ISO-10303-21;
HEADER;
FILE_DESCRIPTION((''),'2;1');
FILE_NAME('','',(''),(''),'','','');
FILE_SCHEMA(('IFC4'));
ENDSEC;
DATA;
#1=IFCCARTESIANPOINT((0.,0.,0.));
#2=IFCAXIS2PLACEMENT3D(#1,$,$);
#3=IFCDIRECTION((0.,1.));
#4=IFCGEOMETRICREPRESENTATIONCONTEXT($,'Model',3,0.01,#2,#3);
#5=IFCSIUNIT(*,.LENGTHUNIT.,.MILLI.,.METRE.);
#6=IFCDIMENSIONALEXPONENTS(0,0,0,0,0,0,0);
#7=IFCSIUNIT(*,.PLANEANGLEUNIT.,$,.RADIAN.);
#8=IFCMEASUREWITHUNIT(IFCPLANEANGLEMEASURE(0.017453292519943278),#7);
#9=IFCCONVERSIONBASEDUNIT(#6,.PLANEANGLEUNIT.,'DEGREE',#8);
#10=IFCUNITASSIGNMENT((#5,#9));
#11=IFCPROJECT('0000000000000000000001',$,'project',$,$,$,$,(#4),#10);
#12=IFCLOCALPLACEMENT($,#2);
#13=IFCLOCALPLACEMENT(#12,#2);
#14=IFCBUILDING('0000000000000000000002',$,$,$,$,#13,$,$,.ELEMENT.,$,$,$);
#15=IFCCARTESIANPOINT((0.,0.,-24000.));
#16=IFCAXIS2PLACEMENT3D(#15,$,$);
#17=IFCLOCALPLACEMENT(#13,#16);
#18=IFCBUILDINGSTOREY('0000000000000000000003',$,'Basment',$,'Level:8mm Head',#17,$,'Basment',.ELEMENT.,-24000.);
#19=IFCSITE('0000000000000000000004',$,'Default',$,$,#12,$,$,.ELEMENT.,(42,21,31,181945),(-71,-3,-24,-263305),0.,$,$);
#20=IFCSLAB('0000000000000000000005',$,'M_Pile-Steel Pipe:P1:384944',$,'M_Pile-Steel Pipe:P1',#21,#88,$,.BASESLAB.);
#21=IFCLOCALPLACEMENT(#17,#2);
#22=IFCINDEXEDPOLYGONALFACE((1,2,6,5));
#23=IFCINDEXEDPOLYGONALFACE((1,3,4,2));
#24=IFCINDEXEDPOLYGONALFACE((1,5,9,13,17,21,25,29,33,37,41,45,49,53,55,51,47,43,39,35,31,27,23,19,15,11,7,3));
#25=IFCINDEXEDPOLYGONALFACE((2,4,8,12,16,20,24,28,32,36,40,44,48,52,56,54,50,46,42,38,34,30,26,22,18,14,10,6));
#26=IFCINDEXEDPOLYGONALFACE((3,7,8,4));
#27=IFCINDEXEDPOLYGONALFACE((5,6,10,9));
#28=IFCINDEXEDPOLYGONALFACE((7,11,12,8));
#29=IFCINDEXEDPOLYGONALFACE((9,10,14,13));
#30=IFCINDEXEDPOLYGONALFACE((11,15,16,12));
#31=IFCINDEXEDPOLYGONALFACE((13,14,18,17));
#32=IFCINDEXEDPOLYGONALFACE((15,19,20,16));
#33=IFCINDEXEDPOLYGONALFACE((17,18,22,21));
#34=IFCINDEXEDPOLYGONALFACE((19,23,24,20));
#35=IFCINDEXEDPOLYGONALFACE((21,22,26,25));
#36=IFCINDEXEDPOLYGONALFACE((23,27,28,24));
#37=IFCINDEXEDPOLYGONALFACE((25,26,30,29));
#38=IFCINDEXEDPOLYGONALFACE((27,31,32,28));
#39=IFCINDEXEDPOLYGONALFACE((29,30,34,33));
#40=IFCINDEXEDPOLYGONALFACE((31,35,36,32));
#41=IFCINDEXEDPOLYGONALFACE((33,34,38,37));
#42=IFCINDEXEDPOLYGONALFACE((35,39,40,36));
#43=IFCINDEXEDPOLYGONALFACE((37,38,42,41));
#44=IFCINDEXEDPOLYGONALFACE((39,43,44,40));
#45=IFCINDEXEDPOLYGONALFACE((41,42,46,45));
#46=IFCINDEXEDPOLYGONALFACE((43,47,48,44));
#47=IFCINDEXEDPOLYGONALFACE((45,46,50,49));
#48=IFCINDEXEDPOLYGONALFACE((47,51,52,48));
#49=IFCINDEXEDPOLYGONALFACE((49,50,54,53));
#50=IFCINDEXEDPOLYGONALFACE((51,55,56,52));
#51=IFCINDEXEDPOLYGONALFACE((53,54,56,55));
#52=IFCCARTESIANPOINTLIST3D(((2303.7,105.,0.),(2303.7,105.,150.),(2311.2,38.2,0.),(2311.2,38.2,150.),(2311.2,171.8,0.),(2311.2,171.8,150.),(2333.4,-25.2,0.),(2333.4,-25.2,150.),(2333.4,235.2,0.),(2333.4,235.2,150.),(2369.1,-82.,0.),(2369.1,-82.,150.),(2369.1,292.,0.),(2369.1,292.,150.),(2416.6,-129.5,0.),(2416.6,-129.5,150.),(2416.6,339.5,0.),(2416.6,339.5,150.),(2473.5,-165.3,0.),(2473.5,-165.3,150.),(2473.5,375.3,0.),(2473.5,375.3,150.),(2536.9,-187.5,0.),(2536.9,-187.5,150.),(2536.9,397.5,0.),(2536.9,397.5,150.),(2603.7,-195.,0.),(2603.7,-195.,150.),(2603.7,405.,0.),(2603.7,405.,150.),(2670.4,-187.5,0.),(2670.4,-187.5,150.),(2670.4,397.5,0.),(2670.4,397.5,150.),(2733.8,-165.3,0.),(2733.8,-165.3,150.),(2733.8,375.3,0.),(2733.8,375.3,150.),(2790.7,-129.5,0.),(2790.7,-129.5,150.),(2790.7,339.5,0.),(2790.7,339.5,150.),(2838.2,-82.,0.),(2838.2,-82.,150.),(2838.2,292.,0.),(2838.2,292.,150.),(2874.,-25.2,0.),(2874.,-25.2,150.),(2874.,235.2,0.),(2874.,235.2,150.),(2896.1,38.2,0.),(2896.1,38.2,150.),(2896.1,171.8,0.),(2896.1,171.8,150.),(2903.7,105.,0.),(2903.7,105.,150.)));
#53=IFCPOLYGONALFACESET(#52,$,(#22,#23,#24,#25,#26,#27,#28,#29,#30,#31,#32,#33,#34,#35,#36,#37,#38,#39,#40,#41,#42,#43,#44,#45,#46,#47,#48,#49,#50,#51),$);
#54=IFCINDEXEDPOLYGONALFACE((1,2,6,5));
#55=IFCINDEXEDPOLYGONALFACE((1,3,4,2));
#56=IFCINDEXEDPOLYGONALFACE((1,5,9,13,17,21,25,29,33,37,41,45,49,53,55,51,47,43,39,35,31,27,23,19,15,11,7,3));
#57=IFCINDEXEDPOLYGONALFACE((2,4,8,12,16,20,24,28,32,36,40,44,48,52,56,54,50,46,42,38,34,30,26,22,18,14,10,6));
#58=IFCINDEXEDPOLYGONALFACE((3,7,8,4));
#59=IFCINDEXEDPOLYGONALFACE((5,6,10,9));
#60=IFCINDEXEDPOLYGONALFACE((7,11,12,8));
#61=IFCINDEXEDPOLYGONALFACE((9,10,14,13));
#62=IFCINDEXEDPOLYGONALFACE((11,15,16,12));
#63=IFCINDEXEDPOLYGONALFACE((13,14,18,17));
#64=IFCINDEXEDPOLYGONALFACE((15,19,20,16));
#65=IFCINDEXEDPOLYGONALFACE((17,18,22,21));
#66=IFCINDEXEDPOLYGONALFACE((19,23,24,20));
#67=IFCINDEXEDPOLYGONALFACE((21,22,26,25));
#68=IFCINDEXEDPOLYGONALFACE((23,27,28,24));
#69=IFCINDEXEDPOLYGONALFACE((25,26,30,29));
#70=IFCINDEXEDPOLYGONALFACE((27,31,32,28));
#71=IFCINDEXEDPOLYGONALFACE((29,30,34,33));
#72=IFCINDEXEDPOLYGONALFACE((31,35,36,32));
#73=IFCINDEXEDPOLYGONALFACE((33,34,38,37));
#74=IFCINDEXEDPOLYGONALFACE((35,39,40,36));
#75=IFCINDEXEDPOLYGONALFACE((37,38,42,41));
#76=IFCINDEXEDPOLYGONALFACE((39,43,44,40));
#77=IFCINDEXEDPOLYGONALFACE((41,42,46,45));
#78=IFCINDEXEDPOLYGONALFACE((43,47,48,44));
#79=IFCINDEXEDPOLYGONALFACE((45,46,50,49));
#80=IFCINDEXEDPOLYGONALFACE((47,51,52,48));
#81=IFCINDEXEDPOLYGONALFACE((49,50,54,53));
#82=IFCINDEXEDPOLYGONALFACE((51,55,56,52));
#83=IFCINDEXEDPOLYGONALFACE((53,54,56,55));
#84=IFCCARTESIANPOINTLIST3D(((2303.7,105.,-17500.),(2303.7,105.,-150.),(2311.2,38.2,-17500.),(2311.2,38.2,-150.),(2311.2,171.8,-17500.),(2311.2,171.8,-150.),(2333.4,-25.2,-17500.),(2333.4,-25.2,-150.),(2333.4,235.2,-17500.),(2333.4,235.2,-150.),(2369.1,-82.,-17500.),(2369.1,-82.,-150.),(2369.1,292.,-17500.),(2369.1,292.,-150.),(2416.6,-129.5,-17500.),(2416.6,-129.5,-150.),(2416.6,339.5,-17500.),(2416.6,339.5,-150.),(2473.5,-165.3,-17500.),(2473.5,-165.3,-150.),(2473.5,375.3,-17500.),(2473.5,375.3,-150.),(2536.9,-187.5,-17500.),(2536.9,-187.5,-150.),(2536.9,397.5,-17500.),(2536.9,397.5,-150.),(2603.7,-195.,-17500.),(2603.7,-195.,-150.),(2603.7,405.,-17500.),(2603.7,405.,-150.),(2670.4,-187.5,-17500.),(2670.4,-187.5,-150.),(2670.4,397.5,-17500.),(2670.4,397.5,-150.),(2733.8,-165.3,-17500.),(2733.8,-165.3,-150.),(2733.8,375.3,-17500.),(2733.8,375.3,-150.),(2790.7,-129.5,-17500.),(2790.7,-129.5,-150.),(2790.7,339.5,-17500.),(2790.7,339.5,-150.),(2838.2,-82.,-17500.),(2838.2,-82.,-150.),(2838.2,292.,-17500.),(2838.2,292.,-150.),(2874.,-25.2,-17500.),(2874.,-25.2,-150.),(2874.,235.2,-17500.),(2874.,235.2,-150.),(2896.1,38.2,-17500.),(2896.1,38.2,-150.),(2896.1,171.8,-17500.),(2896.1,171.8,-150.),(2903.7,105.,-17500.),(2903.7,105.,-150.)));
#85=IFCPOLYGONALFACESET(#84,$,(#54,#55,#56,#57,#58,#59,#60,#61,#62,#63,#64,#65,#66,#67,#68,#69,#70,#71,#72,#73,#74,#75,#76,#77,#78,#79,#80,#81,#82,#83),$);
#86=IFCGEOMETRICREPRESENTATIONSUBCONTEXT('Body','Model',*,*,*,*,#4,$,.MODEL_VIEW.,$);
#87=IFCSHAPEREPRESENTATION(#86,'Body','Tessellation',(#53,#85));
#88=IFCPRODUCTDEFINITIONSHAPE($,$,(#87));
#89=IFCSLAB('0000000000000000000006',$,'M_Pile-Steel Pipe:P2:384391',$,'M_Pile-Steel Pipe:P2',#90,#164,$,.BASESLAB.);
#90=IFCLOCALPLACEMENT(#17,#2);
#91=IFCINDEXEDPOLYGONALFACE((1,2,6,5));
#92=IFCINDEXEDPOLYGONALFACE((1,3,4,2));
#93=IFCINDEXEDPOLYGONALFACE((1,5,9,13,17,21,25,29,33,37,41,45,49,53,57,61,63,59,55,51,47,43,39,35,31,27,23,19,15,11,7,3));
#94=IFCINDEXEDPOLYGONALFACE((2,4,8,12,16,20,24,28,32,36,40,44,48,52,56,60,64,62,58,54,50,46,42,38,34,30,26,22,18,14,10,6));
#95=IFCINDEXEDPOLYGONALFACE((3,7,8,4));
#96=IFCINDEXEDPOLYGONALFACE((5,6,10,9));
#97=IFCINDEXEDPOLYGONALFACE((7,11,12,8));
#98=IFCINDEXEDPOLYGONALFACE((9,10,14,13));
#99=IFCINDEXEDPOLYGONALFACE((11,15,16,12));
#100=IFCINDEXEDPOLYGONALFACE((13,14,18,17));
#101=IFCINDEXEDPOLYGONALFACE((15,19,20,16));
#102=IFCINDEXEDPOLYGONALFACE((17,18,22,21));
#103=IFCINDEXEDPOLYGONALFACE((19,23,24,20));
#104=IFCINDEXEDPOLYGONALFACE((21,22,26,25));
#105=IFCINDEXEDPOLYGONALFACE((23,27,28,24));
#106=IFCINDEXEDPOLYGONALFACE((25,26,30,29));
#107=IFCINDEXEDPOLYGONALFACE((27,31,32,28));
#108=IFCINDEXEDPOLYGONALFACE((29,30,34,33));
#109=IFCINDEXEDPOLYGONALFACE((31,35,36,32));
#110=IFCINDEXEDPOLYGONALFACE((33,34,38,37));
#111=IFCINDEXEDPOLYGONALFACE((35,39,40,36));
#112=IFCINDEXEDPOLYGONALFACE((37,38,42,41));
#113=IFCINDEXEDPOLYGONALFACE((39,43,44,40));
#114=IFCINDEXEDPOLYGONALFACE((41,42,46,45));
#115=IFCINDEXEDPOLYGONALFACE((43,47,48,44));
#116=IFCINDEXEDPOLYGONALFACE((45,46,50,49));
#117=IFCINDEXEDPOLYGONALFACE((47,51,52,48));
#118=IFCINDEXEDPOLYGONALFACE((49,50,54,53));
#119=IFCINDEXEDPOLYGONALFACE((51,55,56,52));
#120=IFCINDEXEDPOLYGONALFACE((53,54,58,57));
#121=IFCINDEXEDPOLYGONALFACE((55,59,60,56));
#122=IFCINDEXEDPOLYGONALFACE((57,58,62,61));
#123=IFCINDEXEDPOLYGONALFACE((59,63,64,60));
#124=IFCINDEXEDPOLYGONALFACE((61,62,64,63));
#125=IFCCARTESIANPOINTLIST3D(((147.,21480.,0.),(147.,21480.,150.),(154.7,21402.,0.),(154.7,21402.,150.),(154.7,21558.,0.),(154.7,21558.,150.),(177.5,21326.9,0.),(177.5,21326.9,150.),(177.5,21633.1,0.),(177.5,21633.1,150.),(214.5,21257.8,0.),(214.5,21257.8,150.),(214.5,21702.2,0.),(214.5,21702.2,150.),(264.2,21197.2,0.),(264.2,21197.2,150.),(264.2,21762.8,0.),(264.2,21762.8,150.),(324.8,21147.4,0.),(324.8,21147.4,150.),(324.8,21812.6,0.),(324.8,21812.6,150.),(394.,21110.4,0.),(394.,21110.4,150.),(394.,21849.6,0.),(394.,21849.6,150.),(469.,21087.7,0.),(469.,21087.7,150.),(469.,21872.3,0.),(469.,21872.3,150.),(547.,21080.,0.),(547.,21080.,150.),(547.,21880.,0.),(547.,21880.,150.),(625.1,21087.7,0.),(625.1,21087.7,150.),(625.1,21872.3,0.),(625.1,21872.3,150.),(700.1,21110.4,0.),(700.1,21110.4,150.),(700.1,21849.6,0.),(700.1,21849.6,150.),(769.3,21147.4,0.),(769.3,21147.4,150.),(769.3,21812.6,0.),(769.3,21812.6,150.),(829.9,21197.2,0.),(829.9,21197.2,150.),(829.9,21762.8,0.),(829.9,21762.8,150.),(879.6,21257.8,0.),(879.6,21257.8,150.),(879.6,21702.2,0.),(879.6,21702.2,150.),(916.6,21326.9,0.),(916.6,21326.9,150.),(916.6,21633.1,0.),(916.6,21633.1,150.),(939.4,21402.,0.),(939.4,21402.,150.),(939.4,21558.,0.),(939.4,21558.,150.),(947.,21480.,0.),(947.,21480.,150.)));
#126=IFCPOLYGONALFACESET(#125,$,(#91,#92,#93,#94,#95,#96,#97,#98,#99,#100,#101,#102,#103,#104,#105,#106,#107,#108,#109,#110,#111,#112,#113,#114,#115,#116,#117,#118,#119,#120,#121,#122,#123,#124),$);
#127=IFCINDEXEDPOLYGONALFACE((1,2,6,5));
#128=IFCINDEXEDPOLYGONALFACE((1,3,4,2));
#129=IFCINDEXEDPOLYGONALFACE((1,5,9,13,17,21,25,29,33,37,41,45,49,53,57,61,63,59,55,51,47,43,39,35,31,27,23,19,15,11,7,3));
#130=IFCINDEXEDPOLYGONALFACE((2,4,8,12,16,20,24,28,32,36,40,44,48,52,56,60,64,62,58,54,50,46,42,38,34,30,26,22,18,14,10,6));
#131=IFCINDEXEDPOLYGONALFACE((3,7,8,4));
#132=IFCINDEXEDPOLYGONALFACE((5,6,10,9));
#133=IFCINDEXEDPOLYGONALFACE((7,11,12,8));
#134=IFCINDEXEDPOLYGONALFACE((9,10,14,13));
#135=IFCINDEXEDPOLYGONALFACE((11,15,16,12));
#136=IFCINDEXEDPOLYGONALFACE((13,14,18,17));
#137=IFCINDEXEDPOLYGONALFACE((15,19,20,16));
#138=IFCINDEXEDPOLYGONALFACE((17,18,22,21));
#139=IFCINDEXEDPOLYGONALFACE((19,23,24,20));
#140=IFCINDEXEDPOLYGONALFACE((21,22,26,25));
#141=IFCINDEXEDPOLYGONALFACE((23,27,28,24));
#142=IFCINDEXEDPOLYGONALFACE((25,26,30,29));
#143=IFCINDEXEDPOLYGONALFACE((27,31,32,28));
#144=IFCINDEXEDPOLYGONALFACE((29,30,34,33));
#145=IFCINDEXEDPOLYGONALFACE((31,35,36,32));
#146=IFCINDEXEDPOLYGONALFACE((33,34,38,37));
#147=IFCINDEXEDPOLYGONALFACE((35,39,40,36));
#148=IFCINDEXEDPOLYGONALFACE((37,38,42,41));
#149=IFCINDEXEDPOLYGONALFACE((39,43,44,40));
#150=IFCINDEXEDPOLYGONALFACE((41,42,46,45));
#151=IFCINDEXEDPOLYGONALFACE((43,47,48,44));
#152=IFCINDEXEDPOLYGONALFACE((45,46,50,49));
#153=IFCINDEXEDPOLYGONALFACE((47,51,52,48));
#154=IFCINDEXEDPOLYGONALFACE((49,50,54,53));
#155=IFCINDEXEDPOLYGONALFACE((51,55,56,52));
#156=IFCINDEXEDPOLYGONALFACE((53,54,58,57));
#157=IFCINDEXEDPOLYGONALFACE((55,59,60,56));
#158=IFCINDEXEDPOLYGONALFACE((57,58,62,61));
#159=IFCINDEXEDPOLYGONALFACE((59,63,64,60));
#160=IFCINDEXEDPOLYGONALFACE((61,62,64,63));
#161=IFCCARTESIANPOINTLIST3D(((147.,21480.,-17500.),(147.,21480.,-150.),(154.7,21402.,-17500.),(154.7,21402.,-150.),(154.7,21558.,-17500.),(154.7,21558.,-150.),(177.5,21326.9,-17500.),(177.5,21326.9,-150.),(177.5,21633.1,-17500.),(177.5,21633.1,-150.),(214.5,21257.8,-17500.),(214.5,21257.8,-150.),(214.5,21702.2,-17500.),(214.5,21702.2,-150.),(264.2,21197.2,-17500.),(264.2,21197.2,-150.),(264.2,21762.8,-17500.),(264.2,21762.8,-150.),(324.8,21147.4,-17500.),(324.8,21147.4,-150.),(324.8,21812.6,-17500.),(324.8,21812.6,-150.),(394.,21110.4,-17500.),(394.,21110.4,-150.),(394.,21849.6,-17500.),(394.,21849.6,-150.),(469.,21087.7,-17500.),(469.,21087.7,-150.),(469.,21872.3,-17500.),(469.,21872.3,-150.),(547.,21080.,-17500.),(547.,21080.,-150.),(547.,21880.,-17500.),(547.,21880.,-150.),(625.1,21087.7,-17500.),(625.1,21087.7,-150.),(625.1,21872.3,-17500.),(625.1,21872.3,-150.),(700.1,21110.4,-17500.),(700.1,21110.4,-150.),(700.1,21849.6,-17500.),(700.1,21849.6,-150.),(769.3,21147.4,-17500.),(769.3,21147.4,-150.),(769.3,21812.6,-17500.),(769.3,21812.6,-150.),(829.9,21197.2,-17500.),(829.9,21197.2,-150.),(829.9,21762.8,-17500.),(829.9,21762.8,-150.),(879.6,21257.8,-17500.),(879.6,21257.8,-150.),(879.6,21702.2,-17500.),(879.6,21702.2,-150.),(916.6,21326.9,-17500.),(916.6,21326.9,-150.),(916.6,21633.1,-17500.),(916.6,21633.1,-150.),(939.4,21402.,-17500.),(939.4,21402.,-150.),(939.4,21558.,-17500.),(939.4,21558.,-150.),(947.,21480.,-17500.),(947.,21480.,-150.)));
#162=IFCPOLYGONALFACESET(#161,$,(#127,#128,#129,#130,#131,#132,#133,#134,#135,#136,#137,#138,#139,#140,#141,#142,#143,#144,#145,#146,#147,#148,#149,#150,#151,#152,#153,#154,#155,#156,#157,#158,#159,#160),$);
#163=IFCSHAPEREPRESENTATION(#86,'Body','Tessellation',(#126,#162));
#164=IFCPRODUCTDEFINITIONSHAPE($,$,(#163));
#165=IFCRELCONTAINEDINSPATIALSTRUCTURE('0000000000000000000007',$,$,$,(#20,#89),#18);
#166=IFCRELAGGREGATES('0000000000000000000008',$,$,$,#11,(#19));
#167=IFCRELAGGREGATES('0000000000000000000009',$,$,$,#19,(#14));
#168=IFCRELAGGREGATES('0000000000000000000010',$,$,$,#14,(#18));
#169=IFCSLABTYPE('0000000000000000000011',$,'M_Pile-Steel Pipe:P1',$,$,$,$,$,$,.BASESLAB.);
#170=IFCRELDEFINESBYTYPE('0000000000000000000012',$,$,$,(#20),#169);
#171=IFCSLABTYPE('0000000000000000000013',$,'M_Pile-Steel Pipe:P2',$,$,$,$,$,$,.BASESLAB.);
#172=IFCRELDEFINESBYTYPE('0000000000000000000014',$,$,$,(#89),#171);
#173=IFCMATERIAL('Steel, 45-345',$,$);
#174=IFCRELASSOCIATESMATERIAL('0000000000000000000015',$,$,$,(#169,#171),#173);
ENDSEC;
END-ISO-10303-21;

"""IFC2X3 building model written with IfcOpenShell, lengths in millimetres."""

from ifc_helpers import new_model, entity, si_unit, converted_unit, direction, frame, frame_2d, origin, place, context, subcontext, project, spatial, circle, extrude, material, type_object, element, save


model = new_model("IFC2X3")

# Units and contexts
model_context = context("Model", 3, precision=0.01, world=origin(), true_north=direction((0.0, 1.0)))
body_context = subcontext(model_context, "Body", "Model", "MODEL_VIEW")
ifc_project = project(units=[si_unit("LENGTHUNIT", "METRE", prefix="MILLI"), converted_unit("PLANEANGLEUNIT", "DEGREE", entity("IfcPlaneAngleMeasure", 0.017453292519943278), si_unit("PLANEANGLEUNIT", "RADIAN"), dimensions=[0, 0, 0, 0, 0, 0, 0])], contexts=[model_context])

# Site, building, storey
site_placement = place(None, origin())
site = spatial("IfcSite", under=ifc_project, at=site_placement, Name="Default", CompositionType="ELEMENT", RefLatitude=(42, 21, 31, 181945), RefLongitude=(-71, -3, -24, -263305), RefElevation=0.0)
building_placement = place(site_placement, origin())
building = spatial("IfcBuilding", under=site, at=building_placement, CompositionType="ELEMENT")
storey_placement = place(building_placement, frame((0.0, 0.0, -24000.0)))
storey = spatial("IfcBuildingStorey", under=building, at=storey_placement, Name="Basment", ObjectType="Level:8mm Head", LongName="Basment", CompositionType="ELEMENT", Elevation=-24000.0)

# Slabs
ifc_material_1 = material(Name="Steel, 45-345")
slab_type_1 = type_object("IfcSlabType", Name="M_Pile-Steel Pipe:P1", PredefinedType="BASESLAB", material=ifc_material_1)
slab_1_placement = place(storey_placement, origin())
element("IfcSlab", 1, at=slab_1_placement, inside=storey, type_object=slab_type_1, Name="M_Pile-Steel Pipe:P1:384944", ObjectType="M_Pile-Steel Pipe:P1", PredefinedType="BASESLAB", context=body_context, shape_type="SweptSolid", body=[
    extrude(circle(Radius=300.0, at=frame_2d((0.0, 0.0), x_axis=(1.0, 0.0))), frame((2603.7, 105.0, 0.0), z_axis=(0.0, 0.0, 1.0), x_axis=(0.0, 1.0, 0.0)), (0.0, 0.0, 1.0), 150.0),
    extrude(circle(Radius=300.0, at=frame_2d((0.0, 0.0), x_axis=(1.0, 0.0))), frame((2603.7, 105.0, -17500.0), z_axis=(0.0, 0.0, 1.0), x_axis=(0.0, 1.0, 0.0)), (0.0, 0.0, 1.0), 17350.0),
])
slab_type_2 = type_object("IfcSlabType", Name="M_Pile-Steel Pipe:P2", PredefinedType="BASESLAB", material=ifc_material_1)
slab_2_placement = place(storey_placement, origin())
element("IfcSlab", 2, at=slab_2_placement, inside=storey, type_object=slab_type_2, Name="M_Pile-Steel Pipe:P2:384391", ObjectType="M_Pile-Steel Pipe:P2", PredefinedType="BASESLAB", context=body_context, shape_type="SweptSolid", body=[
    extrude(circle(Radius=400.0, at=frame_2d((0.0, 0.0), x_axis=(1.0, 0.0))), frame((547.0, 21480.0, 0.0), z_axis=(0.0, 0.0, 1.0), x_axis=(0.0, 1.0, 0.0)), (0.0, 0.0, 1.0), 150.0),
    extrude(circle(Radius=400.0, at=frame_2d((0.0, 0.0), x_axis=(1.0, 0.0))), frame((547.0, 21480.0, -17500.0), z_axis=(0.0, 0.0, 1.0), x_axis=(0.0, 1.0, 0.0)), (0.0, 0.0, 1.0), 17350.0),
])

save(model, "model.ifc")
